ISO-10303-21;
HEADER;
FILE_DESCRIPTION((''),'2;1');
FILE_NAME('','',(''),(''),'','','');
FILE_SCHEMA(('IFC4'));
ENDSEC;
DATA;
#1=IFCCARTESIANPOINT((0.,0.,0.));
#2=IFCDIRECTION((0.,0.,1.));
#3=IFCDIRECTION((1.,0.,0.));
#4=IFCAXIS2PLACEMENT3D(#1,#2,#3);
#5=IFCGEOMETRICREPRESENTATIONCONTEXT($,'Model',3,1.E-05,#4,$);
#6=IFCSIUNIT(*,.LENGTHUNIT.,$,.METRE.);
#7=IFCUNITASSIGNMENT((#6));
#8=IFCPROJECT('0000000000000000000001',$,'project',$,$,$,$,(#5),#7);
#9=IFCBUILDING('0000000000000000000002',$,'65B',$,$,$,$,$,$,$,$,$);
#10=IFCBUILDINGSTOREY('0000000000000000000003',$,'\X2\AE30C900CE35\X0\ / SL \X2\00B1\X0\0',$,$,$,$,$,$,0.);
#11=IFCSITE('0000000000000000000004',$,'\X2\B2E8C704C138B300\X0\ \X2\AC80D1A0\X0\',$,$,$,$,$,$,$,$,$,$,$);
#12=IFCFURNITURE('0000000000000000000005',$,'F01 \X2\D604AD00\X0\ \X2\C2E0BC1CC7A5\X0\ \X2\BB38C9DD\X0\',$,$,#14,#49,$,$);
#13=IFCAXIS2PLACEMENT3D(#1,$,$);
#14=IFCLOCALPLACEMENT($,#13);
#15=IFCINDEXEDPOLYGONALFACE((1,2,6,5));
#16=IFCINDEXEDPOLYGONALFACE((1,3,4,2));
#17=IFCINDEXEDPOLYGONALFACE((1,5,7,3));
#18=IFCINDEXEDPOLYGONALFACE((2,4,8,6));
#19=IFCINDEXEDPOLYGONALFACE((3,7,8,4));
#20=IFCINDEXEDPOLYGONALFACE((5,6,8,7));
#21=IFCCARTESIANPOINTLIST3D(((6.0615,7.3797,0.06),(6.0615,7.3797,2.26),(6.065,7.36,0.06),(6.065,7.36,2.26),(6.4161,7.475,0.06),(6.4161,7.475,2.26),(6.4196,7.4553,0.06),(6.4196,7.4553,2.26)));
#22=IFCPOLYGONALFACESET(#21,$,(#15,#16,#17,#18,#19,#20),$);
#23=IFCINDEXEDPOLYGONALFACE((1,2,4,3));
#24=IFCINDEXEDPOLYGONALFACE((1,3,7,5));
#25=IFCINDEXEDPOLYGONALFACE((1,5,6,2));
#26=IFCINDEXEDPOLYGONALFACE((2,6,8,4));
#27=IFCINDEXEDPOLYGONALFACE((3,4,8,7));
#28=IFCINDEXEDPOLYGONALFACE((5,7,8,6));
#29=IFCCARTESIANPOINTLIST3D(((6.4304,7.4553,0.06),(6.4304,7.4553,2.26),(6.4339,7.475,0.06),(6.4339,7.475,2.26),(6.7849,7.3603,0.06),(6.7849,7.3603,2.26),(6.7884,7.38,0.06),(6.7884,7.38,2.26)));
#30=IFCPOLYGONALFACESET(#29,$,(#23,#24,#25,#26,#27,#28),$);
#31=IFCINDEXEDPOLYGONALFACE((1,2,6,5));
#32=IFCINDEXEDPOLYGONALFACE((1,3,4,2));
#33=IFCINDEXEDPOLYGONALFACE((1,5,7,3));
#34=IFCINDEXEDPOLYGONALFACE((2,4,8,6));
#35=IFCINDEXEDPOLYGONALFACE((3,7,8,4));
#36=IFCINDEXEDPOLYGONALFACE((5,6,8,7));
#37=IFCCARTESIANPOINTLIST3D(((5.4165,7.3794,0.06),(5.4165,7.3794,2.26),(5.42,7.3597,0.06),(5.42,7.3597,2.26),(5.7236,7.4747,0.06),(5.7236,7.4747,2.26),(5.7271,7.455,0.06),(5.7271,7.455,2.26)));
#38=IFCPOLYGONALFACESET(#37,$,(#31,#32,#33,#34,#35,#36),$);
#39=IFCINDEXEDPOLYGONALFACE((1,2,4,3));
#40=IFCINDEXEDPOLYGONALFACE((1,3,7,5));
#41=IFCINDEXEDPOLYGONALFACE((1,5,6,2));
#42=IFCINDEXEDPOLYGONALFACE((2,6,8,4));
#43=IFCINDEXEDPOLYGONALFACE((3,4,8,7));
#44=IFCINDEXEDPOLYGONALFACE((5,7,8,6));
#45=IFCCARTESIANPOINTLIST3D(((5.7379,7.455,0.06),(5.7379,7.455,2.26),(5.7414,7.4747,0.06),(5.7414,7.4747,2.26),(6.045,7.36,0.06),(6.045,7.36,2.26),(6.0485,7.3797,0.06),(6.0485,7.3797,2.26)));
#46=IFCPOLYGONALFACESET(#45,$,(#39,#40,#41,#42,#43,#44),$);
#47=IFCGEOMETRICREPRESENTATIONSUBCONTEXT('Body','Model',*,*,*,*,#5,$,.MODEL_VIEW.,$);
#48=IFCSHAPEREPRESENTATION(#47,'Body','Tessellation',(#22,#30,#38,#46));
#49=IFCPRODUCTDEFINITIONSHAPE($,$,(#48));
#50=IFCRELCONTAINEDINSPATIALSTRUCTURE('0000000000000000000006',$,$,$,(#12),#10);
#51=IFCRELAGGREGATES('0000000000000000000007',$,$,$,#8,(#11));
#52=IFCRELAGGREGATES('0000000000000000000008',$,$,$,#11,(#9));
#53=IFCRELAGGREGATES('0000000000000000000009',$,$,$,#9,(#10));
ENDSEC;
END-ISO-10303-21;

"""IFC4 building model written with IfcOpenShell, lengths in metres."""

from ifc_helpers import new_model, si_unit, frame, origin_with_axes, place, context, subcontext, project, spatial, polyline, outline, extrude, element, save


model = new_model("IFC4")

# Units and contexts
model_context = context("Model", 3, precision=1e-05, world=origin_with_axes())
body_context = subcontext(model_context, "Body", "Model", "MODEL_VIEW")
ifc_project = project(units=[si_unit("LENGTHUNIT", "METRE")], contexts=[model_context])

# Site, building, storey
site = spatial("IfcSite", under=ifc_project, Name="단위세대 검토")
building = spatial("IfcBuilding", under=site, Name="65B")
storey = spatial("IfcBuildingStorey", under=building, Name="기준층 / SL ±0", Elevation=0.0)

# Furniture
furniture_1_placement = place(None, origin_with_axes())
element("IfcFurniture", 1, at=furniture_1_placement, inside=storey, Name="F01 현관 신발장 문짝", context=body_context, shape_type="SweptSolid", body=[
    extrude(outline(polyline([(6.065, 7.36), (6.0615, 7.3797), (6.4161, 7.475), (6.4196, 7.4553), (6.065, 7.36)])), frame((0.0, 0.0, 0.06)), (0.0, 0.0, 1.0), 2.2),
    extrude(outline(polyline([(6.7849, 7.3603), (6.7884, 7.38), (6.4339, 7.475), (6.4304, 7.4553), (6.7849, 7.3603)])), frame((0.0, 0.0, 0.06)), (0.0, 0.0, 1.0), 2.2),
    extrude(outline(polyline([(5.42, 7.3597), (5.4165, 7.3794), (5.7236, 7.4747), (5.7271, 7.455), (5.42, 7.3597)])), frame((0.0, 0.0, 0.06)), (0.0, 0.0, 1.0), 2.2),
    extrude(outline(polyline([(6.045, 7.36), (6.0485, 7.3797), (5.7414, 7.4747), (5.7379, 7.455), (6.045, 7.36)])), frame((0.0, 0.0, 0.06)), (0.0, 0.0, 1.0), 2.2),
])

save(model, "model.ifc")
